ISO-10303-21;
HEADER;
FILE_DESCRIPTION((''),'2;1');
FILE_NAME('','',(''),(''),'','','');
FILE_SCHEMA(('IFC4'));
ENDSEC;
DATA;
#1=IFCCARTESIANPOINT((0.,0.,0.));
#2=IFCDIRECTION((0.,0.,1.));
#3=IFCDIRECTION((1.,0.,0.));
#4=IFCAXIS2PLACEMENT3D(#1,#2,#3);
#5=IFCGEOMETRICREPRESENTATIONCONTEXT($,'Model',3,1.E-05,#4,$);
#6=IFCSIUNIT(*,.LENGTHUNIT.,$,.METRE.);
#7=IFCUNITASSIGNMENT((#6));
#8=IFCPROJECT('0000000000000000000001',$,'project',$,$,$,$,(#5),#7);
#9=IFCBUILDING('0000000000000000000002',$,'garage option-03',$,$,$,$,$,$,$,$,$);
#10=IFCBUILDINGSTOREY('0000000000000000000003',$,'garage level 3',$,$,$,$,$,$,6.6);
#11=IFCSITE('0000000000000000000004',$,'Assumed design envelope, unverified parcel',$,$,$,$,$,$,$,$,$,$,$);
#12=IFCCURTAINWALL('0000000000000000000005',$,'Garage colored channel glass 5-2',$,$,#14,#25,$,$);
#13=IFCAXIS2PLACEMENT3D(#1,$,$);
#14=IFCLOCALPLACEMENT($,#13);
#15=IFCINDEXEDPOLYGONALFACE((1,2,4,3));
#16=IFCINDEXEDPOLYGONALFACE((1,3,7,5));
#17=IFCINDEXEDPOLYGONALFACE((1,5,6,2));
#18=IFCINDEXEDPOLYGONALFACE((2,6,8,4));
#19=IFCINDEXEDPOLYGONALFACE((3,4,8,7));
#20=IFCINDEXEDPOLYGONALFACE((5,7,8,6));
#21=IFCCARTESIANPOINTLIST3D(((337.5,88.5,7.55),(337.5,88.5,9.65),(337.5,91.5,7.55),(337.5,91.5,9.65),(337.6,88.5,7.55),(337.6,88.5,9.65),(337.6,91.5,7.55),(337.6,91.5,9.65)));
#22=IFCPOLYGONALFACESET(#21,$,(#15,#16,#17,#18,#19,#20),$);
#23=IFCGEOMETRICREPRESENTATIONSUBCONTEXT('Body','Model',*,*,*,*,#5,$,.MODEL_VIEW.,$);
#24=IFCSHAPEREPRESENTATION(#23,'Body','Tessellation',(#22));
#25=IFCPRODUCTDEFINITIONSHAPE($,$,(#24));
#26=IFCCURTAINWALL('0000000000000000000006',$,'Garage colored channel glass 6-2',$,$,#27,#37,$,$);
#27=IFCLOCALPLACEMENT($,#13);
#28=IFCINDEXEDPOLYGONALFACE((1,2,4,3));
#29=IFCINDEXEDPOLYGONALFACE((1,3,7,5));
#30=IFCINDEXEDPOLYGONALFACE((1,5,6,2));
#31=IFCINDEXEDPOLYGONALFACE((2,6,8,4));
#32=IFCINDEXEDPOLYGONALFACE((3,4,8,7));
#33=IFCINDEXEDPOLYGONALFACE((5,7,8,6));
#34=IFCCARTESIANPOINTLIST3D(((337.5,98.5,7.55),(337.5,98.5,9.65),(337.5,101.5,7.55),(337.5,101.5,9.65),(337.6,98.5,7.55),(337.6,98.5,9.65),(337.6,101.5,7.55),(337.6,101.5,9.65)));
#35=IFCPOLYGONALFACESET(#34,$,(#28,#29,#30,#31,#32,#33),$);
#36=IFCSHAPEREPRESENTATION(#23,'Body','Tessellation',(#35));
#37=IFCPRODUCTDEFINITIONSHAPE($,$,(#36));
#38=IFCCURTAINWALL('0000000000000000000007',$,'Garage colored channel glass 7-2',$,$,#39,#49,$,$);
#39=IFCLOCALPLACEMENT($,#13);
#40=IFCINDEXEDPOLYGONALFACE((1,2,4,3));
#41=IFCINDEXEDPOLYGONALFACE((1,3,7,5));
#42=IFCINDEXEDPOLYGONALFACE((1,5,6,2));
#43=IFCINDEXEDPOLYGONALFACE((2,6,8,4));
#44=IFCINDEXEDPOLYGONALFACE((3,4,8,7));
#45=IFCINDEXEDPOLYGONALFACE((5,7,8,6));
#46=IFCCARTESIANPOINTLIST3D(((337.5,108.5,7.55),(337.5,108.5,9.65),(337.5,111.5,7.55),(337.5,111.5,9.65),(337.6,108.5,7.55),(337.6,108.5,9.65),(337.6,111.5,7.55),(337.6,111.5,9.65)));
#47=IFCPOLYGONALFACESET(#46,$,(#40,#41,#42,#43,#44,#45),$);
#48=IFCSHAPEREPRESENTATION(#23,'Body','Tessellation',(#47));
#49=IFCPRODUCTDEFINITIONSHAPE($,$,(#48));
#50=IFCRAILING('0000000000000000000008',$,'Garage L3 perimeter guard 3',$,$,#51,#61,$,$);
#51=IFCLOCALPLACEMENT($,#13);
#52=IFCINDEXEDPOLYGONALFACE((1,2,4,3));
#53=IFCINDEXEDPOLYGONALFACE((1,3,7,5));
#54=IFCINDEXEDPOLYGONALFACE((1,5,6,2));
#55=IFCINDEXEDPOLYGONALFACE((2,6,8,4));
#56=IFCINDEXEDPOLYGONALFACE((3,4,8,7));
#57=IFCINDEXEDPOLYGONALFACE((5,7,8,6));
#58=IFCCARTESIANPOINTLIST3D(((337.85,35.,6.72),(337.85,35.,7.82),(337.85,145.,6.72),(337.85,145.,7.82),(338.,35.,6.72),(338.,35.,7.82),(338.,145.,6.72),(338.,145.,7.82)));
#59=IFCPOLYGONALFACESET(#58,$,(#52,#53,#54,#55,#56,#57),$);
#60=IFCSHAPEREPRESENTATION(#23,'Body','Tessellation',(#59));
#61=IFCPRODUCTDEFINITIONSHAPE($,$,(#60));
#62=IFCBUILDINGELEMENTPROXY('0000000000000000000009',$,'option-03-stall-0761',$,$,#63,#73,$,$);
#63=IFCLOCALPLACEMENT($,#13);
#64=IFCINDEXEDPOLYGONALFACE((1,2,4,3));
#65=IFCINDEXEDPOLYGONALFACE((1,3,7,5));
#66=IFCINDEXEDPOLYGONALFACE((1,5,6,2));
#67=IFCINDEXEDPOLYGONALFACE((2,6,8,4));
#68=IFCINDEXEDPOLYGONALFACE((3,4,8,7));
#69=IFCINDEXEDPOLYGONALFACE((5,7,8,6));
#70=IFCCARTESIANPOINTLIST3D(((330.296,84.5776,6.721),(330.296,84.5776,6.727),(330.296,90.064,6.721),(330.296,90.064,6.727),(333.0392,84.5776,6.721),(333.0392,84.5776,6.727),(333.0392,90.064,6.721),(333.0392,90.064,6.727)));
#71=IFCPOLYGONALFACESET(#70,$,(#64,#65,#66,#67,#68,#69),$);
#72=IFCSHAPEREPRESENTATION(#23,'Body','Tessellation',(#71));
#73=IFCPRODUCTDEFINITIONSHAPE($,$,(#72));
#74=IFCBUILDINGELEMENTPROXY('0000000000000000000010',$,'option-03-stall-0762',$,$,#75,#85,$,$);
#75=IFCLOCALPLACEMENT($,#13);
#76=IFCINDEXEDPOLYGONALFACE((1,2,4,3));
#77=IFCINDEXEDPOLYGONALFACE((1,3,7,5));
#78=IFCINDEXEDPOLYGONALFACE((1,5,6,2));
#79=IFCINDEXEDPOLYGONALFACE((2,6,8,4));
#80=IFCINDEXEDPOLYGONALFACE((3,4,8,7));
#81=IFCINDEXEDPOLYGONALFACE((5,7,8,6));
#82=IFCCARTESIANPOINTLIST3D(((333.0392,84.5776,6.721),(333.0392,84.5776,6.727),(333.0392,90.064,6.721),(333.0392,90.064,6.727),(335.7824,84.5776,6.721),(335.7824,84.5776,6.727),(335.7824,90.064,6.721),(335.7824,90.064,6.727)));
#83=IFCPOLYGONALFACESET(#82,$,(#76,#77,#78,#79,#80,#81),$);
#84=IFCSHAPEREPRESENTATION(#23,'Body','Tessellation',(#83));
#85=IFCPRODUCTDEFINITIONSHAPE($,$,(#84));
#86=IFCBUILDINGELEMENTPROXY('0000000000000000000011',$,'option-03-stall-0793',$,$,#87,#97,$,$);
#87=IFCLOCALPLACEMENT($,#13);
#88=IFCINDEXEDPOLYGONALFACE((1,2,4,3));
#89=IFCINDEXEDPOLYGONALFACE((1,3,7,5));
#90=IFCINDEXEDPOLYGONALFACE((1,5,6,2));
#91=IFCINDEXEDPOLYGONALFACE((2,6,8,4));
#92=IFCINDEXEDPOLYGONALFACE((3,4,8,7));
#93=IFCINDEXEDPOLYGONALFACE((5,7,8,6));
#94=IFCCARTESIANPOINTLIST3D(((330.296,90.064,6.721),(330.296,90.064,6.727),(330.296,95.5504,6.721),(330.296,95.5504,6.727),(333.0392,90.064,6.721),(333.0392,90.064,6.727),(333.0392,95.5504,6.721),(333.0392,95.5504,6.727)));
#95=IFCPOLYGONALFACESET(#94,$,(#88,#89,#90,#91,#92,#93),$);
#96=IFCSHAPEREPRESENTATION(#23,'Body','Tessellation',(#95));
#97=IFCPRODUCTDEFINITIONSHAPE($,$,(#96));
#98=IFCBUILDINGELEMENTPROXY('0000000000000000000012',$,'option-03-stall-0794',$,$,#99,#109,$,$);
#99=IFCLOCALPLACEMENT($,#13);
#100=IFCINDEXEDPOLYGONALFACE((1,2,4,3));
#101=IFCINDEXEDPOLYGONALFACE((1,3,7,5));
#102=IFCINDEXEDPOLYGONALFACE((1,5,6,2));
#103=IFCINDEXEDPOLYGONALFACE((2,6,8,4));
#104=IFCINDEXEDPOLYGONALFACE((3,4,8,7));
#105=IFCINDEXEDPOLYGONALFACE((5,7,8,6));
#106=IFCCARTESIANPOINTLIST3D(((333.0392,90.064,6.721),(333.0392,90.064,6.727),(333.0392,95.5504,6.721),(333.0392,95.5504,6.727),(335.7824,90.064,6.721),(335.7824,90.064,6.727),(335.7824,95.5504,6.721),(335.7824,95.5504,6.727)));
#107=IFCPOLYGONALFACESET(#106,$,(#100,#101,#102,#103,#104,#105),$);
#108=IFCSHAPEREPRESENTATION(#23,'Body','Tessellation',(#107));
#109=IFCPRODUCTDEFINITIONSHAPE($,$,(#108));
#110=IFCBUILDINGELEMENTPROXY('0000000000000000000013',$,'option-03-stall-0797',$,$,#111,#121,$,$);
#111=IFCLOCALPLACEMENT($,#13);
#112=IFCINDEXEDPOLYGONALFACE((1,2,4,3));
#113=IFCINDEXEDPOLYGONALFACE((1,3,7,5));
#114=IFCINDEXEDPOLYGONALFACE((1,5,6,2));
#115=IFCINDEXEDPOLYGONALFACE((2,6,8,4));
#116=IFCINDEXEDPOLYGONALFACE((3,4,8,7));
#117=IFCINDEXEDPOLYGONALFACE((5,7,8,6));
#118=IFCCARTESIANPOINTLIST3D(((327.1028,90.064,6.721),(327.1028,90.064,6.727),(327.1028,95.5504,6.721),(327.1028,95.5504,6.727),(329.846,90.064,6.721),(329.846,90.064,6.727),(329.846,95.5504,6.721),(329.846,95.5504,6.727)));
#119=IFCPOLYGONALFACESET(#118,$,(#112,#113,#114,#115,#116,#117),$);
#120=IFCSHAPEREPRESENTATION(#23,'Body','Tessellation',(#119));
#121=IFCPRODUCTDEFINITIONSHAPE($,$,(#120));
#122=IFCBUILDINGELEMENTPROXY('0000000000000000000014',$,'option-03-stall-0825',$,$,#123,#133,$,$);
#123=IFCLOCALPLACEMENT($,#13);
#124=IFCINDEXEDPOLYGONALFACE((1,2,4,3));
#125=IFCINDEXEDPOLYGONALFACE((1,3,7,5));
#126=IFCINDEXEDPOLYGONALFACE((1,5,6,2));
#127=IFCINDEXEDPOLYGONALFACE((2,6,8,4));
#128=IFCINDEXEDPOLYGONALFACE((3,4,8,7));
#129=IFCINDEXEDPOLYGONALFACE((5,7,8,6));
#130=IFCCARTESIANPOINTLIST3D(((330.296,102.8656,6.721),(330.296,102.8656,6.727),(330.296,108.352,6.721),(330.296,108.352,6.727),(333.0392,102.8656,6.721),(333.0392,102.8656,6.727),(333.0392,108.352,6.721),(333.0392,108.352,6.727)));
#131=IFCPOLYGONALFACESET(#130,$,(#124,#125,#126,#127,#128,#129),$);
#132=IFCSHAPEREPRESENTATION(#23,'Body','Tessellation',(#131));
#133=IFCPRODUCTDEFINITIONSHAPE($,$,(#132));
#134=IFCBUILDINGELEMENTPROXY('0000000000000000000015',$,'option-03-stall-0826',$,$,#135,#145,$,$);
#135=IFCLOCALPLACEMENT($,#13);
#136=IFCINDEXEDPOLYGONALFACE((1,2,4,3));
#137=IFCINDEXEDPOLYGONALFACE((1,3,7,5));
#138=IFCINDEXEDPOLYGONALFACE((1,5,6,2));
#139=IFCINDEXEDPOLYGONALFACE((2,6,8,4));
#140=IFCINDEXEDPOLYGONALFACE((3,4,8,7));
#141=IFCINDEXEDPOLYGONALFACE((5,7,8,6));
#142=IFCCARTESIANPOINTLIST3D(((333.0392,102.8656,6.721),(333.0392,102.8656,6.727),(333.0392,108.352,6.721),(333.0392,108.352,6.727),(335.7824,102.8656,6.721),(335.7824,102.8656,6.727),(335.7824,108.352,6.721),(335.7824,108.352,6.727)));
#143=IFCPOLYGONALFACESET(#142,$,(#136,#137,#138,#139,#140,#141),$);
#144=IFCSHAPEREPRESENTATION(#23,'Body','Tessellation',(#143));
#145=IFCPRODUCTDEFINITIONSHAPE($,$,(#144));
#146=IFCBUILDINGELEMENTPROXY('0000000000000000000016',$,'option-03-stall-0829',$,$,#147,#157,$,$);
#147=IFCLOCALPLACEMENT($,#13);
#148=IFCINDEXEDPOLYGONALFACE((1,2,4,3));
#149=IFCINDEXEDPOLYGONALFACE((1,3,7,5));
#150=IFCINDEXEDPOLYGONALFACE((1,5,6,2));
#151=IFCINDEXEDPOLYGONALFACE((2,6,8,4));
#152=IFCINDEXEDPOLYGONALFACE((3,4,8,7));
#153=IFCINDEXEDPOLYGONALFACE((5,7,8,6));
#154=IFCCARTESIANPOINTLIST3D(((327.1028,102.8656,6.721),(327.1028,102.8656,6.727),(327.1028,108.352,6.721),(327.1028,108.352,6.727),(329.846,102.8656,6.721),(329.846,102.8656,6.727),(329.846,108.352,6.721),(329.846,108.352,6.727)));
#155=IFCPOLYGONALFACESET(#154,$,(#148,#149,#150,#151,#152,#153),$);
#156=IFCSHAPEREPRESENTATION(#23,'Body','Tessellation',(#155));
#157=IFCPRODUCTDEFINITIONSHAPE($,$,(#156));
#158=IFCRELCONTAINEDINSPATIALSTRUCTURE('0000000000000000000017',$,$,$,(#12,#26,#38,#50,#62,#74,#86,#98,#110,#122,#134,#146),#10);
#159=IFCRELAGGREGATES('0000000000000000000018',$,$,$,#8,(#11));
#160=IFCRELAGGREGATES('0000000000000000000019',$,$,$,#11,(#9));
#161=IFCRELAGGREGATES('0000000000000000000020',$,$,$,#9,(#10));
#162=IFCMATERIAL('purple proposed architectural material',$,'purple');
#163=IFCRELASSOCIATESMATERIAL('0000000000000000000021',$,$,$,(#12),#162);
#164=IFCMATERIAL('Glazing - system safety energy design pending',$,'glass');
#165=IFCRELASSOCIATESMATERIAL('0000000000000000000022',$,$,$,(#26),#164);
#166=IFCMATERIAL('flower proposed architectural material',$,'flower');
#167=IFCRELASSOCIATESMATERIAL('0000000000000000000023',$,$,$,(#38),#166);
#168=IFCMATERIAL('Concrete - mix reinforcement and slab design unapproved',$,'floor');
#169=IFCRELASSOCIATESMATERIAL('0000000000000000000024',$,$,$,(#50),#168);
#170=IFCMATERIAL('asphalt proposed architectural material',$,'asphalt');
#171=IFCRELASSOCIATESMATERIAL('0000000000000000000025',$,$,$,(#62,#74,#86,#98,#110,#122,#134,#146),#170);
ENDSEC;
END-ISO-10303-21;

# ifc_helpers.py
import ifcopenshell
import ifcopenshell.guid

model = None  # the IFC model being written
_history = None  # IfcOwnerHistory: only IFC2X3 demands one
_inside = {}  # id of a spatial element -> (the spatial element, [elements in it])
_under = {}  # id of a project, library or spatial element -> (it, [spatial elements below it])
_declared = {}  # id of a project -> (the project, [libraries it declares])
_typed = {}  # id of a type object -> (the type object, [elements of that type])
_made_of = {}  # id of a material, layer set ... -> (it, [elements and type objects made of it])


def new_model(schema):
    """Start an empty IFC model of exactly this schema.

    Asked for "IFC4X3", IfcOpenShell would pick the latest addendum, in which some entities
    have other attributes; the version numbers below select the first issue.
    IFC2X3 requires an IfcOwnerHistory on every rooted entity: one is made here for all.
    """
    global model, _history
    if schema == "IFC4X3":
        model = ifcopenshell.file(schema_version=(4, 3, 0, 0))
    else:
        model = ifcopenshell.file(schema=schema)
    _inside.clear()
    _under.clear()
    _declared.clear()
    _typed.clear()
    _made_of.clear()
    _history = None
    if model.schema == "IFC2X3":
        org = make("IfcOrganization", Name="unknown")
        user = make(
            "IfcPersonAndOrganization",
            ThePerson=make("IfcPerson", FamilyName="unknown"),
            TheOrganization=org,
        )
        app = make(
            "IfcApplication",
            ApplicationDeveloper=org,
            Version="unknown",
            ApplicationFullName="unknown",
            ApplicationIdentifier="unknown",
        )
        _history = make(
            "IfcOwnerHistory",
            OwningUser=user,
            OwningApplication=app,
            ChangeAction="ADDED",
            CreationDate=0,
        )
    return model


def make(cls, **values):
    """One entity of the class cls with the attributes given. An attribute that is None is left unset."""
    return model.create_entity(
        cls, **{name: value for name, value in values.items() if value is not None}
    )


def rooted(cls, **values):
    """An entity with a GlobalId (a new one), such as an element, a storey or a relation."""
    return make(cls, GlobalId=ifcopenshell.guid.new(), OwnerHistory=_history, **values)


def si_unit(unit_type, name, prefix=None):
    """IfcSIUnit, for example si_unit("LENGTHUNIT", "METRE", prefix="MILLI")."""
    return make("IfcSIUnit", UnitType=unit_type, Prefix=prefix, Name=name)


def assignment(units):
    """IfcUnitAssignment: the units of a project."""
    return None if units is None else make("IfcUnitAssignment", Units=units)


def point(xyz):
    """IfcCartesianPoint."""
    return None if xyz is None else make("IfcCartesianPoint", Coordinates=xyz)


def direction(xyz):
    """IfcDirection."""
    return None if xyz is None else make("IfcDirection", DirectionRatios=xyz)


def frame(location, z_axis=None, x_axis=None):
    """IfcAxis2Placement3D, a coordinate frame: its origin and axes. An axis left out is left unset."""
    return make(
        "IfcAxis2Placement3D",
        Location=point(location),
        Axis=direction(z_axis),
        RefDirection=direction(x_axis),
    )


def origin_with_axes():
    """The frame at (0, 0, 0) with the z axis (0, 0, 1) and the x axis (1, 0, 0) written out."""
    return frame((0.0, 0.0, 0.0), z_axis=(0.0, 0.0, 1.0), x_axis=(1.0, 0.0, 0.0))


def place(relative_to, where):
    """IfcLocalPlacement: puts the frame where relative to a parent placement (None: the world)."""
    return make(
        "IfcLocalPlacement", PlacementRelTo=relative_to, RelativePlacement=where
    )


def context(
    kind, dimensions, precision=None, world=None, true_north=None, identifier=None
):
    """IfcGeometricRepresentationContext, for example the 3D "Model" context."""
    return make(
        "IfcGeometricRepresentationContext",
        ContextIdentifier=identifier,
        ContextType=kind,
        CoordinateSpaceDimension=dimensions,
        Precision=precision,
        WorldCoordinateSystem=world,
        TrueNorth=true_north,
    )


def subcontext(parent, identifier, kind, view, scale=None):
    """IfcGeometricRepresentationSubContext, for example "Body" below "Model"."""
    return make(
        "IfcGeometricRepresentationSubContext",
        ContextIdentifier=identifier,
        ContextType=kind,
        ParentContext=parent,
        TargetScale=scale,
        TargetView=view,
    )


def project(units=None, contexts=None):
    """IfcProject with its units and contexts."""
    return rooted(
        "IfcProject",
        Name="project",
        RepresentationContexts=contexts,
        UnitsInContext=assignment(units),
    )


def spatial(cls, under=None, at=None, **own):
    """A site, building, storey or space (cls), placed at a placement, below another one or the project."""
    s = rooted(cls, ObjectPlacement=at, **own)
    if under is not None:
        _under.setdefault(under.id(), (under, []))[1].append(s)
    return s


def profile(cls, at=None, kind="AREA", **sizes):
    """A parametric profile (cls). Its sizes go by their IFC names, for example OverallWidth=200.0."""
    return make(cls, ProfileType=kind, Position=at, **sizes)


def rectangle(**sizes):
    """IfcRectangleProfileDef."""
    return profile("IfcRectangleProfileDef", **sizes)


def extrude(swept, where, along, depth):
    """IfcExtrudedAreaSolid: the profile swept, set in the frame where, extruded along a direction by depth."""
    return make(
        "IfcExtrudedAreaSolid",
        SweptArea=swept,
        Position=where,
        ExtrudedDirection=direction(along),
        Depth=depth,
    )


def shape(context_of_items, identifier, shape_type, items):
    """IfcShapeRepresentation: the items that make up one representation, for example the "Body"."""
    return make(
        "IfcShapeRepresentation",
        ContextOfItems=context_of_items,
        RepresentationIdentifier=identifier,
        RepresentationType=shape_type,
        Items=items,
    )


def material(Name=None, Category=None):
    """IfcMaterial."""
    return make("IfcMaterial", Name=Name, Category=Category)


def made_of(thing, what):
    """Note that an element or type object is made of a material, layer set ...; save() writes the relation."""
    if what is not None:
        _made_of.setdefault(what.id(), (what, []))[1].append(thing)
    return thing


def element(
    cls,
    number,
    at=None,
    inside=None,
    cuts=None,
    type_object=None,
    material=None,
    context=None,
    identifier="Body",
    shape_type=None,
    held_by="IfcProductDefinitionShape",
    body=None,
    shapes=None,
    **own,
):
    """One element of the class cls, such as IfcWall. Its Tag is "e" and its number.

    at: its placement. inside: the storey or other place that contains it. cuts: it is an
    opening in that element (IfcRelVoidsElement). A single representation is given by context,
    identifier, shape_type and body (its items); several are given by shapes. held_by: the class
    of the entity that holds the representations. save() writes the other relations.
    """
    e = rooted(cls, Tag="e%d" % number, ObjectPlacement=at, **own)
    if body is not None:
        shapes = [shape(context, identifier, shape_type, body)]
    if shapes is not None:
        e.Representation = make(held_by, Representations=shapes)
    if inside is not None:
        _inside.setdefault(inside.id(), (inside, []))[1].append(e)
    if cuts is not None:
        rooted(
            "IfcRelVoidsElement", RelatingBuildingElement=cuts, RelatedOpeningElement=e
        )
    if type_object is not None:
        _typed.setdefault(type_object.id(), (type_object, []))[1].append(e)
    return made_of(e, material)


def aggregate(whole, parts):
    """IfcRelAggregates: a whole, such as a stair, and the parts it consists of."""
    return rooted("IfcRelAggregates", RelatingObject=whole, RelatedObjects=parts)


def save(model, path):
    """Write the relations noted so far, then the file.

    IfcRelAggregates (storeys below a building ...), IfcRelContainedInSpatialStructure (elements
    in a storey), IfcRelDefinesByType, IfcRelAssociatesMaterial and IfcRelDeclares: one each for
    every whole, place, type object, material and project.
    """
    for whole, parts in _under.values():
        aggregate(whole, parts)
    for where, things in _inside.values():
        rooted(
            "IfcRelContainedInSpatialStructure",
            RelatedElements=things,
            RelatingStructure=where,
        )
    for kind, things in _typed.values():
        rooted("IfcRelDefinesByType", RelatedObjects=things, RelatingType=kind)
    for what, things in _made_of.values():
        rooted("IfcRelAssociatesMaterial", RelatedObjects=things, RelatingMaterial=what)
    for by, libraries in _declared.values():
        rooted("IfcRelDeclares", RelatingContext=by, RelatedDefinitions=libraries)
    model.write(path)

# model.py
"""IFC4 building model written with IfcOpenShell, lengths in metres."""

from ifc_helpers import new_model, si_unit, frame, origin_with_axes, place, context, subcontext, project, spatial, rectangle, extrude, material, element, save


model = new_model("IFC4")

# Units and contexts
model_context = context("Model", 3, precision=1e-05, world=origin_with_axes())
body_context = subcontext(model_context, "Body", "Model", "MODEL_VIEW")
ifc_project = project(units=[si_unit("LENGTHUNIT", "METRE")], contexts=[model_context])

# Site, building, storey
site = spatial("IfcSite", under=ifc_project, Name="Assumed design envelope, unverified parcel")
building = spatial("IfcBuilding", under=site, Name="garage option-03")
storey = spatial("IfcBuildingStorey", under=building, Name="garage level 3", Elevation=6.6)

# Shared definitions
ifc_material_1 = material(Name="Concrete - mix reinforcement and slab design unapproved", Category="floor")

# Curtain walls
ifc_material_2 = material(Name="purple proposed architectural material", Category="purple")
curtain_wall_1_placement = place(None, frame((337.55, 90.0, 7.55), z_axis=(0.0, 0.0, 1.0), x_axis=(1.0, 0.0, 0.0)))
element("IfcCurtainWall", 1, at=curtain_wall_1_placement, inside=storey, material=ifc_material_2, Name="Garage colored channel glass 5-2", context=body_context, shape_type="SweptSolid", body=[
    extrude(rectangle(XDim=0.1, YDim=3.0), origin_with_axes(), (0.0, 0.0, 1.0), 2.1),
])
ifc_material_3 = material(Name="Glazing - system safety energy design pending", Category="glass")
curtain_wall_2_placement = place(None, frame((337.55, 100.0, 7.55), z_axis=(0.0, 0.0, 1.0), x_axis=(1.0, 0.0, 0.0)))
element("IfcCurtainWall", 2, at=curtain_wall_2_placement, inside=storey, material=ifc_material_3, Name="Garage colored channel glass 6-2", context=body_context, shape_type="SweptSolid", body=[
    extrude(rectangle(XDim=0.1, YDim=3.0), origin_with_axes(), (0.0, 0.0, 1.0), 2.1),
])
ifc_material_4 = material(Name="flower proposed architectural material", Category="flower")
curtain_wall_3_placement = place(None, frame((337.55, 110.0, 7.55), z_axis=(0.0, 0.0, 1.0), x_axis=(1.0, 0.0, 0.0)))
element("IfcCurtainWall", 3, at=curtain_wall_3_placement, inside=storey, material=ifc_material_4, Name="Garage colored channel glass 7-2", context=body_context, shape_type="SweptSolid", body=[
    extrude(rectangle(XDim=0.1, YDim=3.0), origin_with_axes(), (0.0, 0.0, 1.0), 2.1),
])

# Railing
railing_placement = place(None, frame((337.925, 90.0, 6.72), z_axis=(0.0, 0.0, 1.0), x_axis=(1.0, 0.0, 0.0)))
element("IfcRailing", 4, at=railing_placement, inside=storey, material=ifc_material_1, Name="Garage L3 perimeter guard 3", context=body_context, shape_type="SweptSolid", body=[
    extrude(rectangle(XDim=0.15, YDim=110.0), origin_with_axes(), (0.0, 0.0, 1.0), 1.1),
])

# Building element proxies
ifc_material_5 = material(Name="asphalt proposed architectural material", Category="asphalt")
for number, where, z_axis, x_axis, name in (
    (5, (331.6676, 87.3208, 6.721), (0.0, 0.0, 1.0), (1.0, 0.0, 0.0), "option-03-stall-0761"),
    (6, (334.4108, 87.3208, 6.721), (0.0, 0.0, 1.0), (1.0, 0.0, 0.0), "option-03-stall-0762"),
    (7, (331.6676, 92.8072, 6.721), (0.0, 0.0, 1.0), (1.0, 0.0, 0.0), "option-03-stall-0793"),
    (8, (334.4108, 92.8072, 6.721), (0.0, 0.0, 1.0), (1.0, 0.0, 0.0), "option-03-stall-0794"),
    (9, (328.4744, 92.8072, 6.721), (0.0, 0.0, 1.0), (1.0, 0.0, 0.0), "option-03-stall-0797"),
    (10, (331.6676, 105.6088, 6.721), (0.0, 0.0, 1.0), (1.0, 0.0, 0.0), "option-03-stall-0825"),
    (11, (334.4108, 105.6088, 6.721), (0.0, 0.0, 1.0), (1.0, 0.0, 0.0), "option-03-stall-0826"),
    (12, (328.4744, 105.6088, 6.721), (0.0, 0.0, 1.0), (1.0, 0.0, 0.0), "option-03-stall-0829"),
):
    element("IfcBuildingElementProxy", number, at=place(None, frame(where, z_axis=z_axis, x_axis=x_axis)), inside=storey, material=ifc_material_5, Name=name, context=body_context, shape_type="SweptSolid", body=[
        extrude(rectangle(XDim=2.7432, YDim=5.4864), origin_with_axes(), (0.0, 0.0, 1.0), 0.006),
    ])

save(model, "model.ifc")
